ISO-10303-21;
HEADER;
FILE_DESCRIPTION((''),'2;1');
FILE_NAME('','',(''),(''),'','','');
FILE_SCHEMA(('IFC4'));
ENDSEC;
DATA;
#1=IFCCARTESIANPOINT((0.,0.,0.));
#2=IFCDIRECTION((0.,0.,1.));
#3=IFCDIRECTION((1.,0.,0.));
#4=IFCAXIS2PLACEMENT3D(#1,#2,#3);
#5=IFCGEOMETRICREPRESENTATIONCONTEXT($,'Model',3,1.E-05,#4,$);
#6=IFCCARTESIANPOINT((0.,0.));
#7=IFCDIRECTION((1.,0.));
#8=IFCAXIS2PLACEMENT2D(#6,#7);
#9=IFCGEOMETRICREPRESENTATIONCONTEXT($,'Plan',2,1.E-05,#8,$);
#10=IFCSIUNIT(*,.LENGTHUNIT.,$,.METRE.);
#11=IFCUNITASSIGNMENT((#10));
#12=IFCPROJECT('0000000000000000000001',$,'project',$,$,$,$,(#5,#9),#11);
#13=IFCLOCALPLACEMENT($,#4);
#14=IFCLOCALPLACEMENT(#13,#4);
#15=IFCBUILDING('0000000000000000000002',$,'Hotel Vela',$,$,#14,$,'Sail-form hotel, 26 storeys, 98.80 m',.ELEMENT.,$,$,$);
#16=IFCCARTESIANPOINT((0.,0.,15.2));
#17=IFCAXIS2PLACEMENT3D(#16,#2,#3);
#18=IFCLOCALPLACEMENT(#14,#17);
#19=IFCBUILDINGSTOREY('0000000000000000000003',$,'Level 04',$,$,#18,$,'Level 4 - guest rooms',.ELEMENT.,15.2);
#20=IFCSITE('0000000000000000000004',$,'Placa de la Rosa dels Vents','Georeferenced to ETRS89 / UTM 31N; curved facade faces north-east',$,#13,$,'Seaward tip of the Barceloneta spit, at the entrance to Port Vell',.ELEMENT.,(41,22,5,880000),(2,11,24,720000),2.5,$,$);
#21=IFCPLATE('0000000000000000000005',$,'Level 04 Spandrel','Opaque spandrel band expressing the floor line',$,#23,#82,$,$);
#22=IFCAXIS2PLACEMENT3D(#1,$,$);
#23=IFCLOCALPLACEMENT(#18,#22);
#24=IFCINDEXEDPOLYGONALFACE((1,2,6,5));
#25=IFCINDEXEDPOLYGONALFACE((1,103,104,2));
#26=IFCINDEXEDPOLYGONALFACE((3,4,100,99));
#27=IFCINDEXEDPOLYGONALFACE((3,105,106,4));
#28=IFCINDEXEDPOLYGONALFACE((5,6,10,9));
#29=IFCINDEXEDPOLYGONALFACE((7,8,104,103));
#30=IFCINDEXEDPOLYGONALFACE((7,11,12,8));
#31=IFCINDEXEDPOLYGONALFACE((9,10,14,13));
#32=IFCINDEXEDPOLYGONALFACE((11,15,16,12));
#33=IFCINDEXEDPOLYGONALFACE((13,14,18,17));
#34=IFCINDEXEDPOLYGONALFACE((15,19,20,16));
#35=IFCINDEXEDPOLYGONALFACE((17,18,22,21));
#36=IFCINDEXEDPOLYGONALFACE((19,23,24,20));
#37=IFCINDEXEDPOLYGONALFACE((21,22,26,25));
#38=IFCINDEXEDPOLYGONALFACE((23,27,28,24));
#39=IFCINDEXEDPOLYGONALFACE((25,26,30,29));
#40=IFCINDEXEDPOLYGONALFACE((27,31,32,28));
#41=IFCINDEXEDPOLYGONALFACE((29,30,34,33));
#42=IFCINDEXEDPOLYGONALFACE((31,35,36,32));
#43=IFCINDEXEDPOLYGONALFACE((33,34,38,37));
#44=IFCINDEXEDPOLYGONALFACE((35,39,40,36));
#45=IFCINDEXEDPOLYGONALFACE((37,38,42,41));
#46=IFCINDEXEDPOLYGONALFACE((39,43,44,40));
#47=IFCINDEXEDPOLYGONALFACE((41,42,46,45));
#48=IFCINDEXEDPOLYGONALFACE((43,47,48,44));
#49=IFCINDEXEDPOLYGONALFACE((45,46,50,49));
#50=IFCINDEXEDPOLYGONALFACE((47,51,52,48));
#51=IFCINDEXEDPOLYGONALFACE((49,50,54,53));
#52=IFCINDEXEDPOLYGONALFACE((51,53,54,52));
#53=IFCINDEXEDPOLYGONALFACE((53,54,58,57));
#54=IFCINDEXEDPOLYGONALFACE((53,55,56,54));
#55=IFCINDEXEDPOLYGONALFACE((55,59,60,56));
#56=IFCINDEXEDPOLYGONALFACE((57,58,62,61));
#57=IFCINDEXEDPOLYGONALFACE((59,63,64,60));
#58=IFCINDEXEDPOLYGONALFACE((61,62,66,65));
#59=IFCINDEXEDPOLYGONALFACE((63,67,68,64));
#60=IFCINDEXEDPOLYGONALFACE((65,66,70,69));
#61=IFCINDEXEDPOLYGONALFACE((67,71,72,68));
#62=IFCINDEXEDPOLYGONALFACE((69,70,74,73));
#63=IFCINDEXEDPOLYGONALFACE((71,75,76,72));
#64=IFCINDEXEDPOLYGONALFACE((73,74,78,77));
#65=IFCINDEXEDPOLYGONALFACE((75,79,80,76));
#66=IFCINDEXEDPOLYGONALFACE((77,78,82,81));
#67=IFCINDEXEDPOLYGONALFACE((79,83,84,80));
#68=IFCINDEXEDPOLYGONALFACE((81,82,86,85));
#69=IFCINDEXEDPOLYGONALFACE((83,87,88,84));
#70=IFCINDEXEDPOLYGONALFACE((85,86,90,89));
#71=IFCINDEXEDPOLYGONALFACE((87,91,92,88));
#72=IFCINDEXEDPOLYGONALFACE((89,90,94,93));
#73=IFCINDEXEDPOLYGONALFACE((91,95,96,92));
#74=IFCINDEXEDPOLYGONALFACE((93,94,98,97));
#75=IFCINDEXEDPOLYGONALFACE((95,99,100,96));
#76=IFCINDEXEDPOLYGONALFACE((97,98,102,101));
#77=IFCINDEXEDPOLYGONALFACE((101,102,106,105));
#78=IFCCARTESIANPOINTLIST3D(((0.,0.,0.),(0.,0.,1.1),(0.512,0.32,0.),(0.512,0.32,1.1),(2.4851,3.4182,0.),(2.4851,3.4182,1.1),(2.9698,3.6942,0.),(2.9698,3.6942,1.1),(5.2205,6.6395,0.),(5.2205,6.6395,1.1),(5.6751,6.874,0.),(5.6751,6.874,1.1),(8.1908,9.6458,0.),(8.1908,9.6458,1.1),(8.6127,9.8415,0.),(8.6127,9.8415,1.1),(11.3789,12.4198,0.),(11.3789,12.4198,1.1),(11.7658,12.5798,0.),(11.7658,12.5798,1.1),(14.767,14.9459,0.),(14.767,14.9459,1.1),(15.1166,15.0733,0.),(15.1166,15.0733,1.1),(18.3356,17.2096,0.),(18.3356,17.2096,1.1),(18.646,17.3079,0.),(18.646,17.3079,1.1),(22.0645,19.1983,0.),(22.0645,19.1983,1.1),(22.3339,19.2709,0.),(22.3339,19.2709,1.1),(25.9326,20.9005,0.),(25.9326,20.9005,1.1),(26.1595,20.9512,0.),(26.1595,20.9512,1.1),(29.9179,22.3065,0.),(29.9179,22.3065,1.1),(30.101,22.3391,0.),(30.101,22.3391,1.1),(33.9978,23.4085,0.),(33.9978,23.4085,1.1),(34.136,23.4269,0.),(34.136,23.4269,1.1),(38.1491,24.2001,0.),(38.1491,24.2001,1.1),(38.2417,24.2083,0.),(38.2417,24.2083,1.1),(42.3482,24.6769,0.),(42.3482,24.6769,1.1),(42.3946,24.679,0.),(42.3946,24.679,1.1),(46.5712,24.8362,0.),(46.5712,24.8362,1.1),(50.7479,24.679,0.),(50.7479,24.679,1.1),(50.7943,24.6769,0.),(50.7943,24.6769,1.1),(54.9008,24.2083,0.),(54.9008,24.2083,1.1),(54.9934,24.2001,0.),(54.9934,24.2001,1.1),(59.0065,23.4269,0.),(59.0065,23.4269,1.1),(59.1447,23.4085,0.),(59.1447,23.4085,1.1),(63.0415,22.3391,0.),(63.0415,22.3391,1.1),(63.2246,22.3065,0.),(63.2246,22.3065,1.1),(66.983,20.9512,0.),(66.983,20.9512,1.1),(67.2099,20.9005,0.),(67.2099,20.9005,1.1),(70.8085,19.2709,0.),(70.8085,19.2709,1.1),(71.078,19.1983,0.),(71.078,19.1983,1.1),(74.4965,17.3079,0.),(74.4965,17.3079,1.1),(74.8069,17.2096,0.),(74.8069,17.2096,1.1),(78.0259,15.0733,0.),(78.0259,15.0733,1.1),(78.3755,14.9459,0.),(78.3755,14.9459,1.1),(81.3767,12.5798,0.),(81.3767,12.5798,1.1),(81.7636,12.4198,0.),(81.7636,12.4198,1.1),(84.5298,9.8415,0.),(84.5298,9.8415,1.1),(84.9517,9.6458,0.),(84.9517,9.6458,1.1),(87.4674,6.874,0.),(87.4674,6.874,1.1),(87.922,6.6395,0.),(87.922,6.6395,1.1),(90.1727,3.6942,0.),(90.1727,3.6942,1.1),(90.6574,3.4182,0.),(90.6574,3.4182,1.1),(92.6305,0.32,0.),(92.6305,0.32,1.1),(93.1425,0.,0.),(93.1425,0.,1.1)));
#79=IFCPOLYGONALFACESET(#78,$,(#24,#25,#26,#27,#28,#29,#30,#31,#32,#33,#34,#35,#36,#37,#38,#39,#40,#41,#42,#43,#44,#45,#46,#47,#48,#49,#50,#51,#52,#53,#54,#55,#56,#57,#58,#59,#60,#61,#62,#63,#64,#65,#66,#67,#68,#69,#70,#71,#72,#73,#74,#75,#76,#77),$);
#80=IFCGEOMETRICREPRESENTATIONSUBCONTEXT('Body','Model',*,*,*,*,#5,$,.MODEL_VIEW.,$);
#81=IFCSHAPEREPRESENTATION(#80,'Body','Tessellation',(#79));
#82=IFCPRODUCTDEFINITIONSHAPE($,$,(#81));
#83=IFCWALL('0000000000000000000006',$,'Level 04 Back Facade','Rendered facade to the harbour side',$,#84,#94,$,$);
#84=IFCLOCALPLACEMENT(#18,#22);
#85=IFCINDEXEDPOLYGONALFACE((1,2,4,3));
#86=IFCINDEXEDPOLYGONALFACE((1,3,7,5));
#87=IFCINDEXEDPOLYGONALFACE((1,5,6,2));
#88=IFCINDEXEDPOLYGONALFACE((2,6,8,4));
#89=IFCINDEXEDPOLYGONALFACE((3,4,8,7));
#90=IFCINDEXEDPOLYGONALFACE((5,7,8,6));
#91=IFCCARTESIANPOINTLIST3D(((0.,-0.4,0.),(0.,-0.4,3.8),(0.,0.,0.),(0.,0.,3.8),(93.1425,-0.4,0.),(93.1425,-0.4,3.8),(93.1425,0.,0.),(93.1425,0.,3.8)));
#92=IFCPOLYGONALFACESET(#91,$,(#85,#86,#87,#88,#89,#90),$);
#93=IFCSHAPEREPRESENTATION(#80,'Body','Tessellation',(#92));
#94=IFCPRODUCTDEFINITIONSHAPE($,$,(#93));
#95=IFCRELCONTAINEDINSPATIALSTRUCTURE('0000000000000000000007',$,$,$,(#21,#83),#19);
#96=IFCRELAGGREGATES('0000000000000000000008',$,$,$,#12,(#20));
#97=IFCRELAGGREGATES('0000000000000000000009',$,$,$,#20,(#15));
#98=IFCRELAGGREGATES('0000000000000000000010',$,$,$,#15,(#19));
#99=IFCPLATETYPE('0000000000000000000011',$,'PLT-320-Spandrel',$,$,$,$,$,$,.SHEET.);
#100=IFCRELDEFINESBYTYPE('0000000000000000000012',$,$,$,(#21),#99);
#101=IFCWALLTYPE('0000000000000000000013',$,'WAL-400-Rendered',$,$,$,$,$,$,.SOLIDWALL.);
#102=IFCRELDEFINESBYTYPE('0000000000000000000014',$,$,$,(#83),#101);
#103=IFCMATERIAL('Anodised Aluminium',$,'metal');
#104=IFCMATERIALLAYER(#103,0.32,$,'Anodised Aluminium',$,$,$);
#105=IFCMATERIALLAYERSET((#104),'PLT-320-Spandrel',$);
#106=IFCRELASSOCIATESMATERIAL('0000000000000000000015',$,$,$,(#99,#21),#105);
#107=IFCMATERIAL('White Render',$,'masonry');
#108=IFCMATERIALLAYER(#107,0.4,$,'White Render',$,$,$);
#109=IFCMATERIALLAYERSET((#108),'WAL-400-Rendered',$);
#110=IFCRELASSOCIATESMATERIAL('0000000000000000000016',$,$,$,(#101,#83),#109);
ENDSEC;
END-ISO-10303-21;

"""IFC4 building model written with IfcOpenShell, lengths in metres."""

from ifc_helpers import new_model, si_unit, frame, origin_with_axes, origin_2d_with_axis, place, context, subcontext, project, spatial, line, indexed_curve, outline, extrude, material, layer, layer_set, layer_usage, type_object, element, save


model = new_model("IFC4")

# Units and contexts
model_context = context("Model", 3, precision=1e-05, world=origin_with_axes())
plan_context = context("Plan", 2, precision=1e-05, world=origin_2d_with_axis())
body_context = subcontext(model_context, "Body", "Model", "MODEL_VIEW")
ifc_project = project(units=[si_unit("LENGTHUNIT", "METRE")], contexts=[model_context, plan_context])

# Site, building, storey
site_placement = place(None, origin_with_axes())
site = spatial("IfcSite", under=ifc_project, at=site_placement, Name="Placa de la Rosa dels Vents", Description="Georeferenced to ETRS89 / UTM 31N; curved facade faces north-east", LongName="Seaward tip of the Barceloneta spit, at the entrance to Port Vell", CompositionType="ELEMENT", RefLatitude=(41, 22, 5, 880000), RefLongitude=(2, 11, 24, 720000), RefElevation=2.5)
building_placement = place(site_placement, origin_with_axes())
building = spatial("IfcBuilding", under=site, at=building_placement, Name="Hotel Vela", LongName="Sail-form hotel, 26 storeys, 98.80 m", CompositionType="ELEMENT")
storey_placement = place(building_placement, frame((0.0, 0.0, 15.2), z_axis=(0.0, 0.0, 1.0), x_axis=(1.0, 0.0, 0.0)))
storey = spatial("IfcBuildingStorey", under=building, at=storey_placement, Name="Level 04", LongName="Level 4 - guest rooms", CompositionType="ELEMENT", Elevation=15.2)

# Plate
ifc_material_1 = material(Name="Anodised Aluminium", Category="metal")
ifc_layer_1 = layer(ifc_material_1, 0.32, Name="Anodised Aluminium")
ifc_layer_set_1 = layer_set([ifc_layer_1], Name="PLT-320-Spandrel")
ifc_layer_usage_1 = layer_usage(ifc_layer_set_1, "AXIS2", "POSITIVE", 0.0)
plate_type_1 = type_object("IfcPlateType", Name="PLT-320-Spandrel", PredefinedType="SHEET", material=ifc_layer_set_1)
plate_1_placement = place(storey_placement, origin_with_axes())
element("IfcPlate", 1, at=plate_1_placement, inside=storey, type_object=plate_type_1, material=ifc_layer_usage_1, Name="Level 04 Spandrel", Description="Opaque spandrel band expressing the floor line", context=body_context, shape_type="SweptSolid", body=[
    extrude(outline(indexed_curve([(93.1425, 0.0), (90.6574, 3.4182), (87.922, 6.6395), (84.9517, 9.6458), (81.7636, 12.4198), (78.3755, 14.9459), (74.8069, 17.2096), (71.078, 19.1983), (67.2099, 20.9005), (63.2246, 22.3065), (59.1447, 23.4085), (54.9934, 24.2001), (50.7943, 24.6769), (46.5712, 24.8362), (42.3482, 24.6769), (38.1491, 24.2001), (33.9978, 23.4085), (29.9179, 22.3065), (25.9326, 20.9005), (22.0645, 19.1983), (18.3356, 17.2096), (14.767, 14.9459), (11.3789, 12.4198), (8.1908, 9.6458), (5.2205, 6.6395), (2.4851, 3.4182), (0.0, 0.0), (92.6305, 0.32), (2.9698, 3.6942), (5.6751, 6.874), (8.6127, 9.8415), (11.7658, 12.5798), (15.1166, 15.0733), (18.646, 17.3079), (22.3339, 19.2709), (26.1595, 20.9512), (30.101, 22.3391), (34.136, 23.4269), (38.2417, 24.2083), (42.3946, 24.679), (46.5712, 24.8362), (50.7479, 24.679), (54.9008, 24.2083), (59.0065, 23.4269), (63.0415, 22.3391), (66.983, 20.9512), (70.8085, 19.2709), (74.4965, 17.3079), (78.0259, 15.0733), (81.3767, 12.5798), (84.5298, 9.8415), (87.4674, 6.874), (90.1727, 3.6942), (0.512, 0.32)], segments=[line(1, 2, 3, 4, 5, 6, 7, 8, 9, 10, 11, 12, 13, 14, 15, 16, 17, 18, 19, 20, 21, 22, 23, 24, 25, 26, 27, 28, 29, 30, 31, 32, 33, 34, 35, 36, 37, 38, 39, 40, 41, 42, 43, 44, 45, 46, 47, 48, 49, 50, 51, 52, 53, 54, 1)])), origin_with_axes(), (0.0, 0.0, 1.0), 1.1),
])

# Wall
ifc_material_2 = material(Name="White Render", Category="masonry")
ifc_layer_2 = layer(ifc_material_2, 0.4, Name="White Render")
ifc_layer_set_2 = layer_set([ifc_layer_2], Name="WAL-400-Rendered")
ifc_layer_usage_2 = layer_usage(ifc_layer_set_2, "AXIS2", "POSITIVE", 0.0)
wall_type = type_object("IfcWallType", Name="WAL-400-Rendered", PredefinedType="SOLIDWALL", material=ifc_layer_set_2)
wall_placement = place(storey_placement, frame((0.0, -0.4, 0.0), z_axis=(0.0, 0.0, 1.0), x_axis=(1.0, 0.0, 0.0)))
element("IfcWall", 2, at=wall_placement, inside=storey, type_object=wall_type, material=ifc_layer_usage_2, Name="Level 04 Back Facade", Description="Rendered facade to the harbour side", context=body_context, shape_type="SweptSolid", body=[
    extrude(outline(indexed_curve([(0.0, 0.0), (93.1425, 0.0), (93.1425, 0.4), (0.0, 0.4)], segments=[line(1, 2, 3, 4, 1)])), origin_with_axes(), (0.0, 0.0, 1.0), 3.8),
])

save(model, "model.ifc")
